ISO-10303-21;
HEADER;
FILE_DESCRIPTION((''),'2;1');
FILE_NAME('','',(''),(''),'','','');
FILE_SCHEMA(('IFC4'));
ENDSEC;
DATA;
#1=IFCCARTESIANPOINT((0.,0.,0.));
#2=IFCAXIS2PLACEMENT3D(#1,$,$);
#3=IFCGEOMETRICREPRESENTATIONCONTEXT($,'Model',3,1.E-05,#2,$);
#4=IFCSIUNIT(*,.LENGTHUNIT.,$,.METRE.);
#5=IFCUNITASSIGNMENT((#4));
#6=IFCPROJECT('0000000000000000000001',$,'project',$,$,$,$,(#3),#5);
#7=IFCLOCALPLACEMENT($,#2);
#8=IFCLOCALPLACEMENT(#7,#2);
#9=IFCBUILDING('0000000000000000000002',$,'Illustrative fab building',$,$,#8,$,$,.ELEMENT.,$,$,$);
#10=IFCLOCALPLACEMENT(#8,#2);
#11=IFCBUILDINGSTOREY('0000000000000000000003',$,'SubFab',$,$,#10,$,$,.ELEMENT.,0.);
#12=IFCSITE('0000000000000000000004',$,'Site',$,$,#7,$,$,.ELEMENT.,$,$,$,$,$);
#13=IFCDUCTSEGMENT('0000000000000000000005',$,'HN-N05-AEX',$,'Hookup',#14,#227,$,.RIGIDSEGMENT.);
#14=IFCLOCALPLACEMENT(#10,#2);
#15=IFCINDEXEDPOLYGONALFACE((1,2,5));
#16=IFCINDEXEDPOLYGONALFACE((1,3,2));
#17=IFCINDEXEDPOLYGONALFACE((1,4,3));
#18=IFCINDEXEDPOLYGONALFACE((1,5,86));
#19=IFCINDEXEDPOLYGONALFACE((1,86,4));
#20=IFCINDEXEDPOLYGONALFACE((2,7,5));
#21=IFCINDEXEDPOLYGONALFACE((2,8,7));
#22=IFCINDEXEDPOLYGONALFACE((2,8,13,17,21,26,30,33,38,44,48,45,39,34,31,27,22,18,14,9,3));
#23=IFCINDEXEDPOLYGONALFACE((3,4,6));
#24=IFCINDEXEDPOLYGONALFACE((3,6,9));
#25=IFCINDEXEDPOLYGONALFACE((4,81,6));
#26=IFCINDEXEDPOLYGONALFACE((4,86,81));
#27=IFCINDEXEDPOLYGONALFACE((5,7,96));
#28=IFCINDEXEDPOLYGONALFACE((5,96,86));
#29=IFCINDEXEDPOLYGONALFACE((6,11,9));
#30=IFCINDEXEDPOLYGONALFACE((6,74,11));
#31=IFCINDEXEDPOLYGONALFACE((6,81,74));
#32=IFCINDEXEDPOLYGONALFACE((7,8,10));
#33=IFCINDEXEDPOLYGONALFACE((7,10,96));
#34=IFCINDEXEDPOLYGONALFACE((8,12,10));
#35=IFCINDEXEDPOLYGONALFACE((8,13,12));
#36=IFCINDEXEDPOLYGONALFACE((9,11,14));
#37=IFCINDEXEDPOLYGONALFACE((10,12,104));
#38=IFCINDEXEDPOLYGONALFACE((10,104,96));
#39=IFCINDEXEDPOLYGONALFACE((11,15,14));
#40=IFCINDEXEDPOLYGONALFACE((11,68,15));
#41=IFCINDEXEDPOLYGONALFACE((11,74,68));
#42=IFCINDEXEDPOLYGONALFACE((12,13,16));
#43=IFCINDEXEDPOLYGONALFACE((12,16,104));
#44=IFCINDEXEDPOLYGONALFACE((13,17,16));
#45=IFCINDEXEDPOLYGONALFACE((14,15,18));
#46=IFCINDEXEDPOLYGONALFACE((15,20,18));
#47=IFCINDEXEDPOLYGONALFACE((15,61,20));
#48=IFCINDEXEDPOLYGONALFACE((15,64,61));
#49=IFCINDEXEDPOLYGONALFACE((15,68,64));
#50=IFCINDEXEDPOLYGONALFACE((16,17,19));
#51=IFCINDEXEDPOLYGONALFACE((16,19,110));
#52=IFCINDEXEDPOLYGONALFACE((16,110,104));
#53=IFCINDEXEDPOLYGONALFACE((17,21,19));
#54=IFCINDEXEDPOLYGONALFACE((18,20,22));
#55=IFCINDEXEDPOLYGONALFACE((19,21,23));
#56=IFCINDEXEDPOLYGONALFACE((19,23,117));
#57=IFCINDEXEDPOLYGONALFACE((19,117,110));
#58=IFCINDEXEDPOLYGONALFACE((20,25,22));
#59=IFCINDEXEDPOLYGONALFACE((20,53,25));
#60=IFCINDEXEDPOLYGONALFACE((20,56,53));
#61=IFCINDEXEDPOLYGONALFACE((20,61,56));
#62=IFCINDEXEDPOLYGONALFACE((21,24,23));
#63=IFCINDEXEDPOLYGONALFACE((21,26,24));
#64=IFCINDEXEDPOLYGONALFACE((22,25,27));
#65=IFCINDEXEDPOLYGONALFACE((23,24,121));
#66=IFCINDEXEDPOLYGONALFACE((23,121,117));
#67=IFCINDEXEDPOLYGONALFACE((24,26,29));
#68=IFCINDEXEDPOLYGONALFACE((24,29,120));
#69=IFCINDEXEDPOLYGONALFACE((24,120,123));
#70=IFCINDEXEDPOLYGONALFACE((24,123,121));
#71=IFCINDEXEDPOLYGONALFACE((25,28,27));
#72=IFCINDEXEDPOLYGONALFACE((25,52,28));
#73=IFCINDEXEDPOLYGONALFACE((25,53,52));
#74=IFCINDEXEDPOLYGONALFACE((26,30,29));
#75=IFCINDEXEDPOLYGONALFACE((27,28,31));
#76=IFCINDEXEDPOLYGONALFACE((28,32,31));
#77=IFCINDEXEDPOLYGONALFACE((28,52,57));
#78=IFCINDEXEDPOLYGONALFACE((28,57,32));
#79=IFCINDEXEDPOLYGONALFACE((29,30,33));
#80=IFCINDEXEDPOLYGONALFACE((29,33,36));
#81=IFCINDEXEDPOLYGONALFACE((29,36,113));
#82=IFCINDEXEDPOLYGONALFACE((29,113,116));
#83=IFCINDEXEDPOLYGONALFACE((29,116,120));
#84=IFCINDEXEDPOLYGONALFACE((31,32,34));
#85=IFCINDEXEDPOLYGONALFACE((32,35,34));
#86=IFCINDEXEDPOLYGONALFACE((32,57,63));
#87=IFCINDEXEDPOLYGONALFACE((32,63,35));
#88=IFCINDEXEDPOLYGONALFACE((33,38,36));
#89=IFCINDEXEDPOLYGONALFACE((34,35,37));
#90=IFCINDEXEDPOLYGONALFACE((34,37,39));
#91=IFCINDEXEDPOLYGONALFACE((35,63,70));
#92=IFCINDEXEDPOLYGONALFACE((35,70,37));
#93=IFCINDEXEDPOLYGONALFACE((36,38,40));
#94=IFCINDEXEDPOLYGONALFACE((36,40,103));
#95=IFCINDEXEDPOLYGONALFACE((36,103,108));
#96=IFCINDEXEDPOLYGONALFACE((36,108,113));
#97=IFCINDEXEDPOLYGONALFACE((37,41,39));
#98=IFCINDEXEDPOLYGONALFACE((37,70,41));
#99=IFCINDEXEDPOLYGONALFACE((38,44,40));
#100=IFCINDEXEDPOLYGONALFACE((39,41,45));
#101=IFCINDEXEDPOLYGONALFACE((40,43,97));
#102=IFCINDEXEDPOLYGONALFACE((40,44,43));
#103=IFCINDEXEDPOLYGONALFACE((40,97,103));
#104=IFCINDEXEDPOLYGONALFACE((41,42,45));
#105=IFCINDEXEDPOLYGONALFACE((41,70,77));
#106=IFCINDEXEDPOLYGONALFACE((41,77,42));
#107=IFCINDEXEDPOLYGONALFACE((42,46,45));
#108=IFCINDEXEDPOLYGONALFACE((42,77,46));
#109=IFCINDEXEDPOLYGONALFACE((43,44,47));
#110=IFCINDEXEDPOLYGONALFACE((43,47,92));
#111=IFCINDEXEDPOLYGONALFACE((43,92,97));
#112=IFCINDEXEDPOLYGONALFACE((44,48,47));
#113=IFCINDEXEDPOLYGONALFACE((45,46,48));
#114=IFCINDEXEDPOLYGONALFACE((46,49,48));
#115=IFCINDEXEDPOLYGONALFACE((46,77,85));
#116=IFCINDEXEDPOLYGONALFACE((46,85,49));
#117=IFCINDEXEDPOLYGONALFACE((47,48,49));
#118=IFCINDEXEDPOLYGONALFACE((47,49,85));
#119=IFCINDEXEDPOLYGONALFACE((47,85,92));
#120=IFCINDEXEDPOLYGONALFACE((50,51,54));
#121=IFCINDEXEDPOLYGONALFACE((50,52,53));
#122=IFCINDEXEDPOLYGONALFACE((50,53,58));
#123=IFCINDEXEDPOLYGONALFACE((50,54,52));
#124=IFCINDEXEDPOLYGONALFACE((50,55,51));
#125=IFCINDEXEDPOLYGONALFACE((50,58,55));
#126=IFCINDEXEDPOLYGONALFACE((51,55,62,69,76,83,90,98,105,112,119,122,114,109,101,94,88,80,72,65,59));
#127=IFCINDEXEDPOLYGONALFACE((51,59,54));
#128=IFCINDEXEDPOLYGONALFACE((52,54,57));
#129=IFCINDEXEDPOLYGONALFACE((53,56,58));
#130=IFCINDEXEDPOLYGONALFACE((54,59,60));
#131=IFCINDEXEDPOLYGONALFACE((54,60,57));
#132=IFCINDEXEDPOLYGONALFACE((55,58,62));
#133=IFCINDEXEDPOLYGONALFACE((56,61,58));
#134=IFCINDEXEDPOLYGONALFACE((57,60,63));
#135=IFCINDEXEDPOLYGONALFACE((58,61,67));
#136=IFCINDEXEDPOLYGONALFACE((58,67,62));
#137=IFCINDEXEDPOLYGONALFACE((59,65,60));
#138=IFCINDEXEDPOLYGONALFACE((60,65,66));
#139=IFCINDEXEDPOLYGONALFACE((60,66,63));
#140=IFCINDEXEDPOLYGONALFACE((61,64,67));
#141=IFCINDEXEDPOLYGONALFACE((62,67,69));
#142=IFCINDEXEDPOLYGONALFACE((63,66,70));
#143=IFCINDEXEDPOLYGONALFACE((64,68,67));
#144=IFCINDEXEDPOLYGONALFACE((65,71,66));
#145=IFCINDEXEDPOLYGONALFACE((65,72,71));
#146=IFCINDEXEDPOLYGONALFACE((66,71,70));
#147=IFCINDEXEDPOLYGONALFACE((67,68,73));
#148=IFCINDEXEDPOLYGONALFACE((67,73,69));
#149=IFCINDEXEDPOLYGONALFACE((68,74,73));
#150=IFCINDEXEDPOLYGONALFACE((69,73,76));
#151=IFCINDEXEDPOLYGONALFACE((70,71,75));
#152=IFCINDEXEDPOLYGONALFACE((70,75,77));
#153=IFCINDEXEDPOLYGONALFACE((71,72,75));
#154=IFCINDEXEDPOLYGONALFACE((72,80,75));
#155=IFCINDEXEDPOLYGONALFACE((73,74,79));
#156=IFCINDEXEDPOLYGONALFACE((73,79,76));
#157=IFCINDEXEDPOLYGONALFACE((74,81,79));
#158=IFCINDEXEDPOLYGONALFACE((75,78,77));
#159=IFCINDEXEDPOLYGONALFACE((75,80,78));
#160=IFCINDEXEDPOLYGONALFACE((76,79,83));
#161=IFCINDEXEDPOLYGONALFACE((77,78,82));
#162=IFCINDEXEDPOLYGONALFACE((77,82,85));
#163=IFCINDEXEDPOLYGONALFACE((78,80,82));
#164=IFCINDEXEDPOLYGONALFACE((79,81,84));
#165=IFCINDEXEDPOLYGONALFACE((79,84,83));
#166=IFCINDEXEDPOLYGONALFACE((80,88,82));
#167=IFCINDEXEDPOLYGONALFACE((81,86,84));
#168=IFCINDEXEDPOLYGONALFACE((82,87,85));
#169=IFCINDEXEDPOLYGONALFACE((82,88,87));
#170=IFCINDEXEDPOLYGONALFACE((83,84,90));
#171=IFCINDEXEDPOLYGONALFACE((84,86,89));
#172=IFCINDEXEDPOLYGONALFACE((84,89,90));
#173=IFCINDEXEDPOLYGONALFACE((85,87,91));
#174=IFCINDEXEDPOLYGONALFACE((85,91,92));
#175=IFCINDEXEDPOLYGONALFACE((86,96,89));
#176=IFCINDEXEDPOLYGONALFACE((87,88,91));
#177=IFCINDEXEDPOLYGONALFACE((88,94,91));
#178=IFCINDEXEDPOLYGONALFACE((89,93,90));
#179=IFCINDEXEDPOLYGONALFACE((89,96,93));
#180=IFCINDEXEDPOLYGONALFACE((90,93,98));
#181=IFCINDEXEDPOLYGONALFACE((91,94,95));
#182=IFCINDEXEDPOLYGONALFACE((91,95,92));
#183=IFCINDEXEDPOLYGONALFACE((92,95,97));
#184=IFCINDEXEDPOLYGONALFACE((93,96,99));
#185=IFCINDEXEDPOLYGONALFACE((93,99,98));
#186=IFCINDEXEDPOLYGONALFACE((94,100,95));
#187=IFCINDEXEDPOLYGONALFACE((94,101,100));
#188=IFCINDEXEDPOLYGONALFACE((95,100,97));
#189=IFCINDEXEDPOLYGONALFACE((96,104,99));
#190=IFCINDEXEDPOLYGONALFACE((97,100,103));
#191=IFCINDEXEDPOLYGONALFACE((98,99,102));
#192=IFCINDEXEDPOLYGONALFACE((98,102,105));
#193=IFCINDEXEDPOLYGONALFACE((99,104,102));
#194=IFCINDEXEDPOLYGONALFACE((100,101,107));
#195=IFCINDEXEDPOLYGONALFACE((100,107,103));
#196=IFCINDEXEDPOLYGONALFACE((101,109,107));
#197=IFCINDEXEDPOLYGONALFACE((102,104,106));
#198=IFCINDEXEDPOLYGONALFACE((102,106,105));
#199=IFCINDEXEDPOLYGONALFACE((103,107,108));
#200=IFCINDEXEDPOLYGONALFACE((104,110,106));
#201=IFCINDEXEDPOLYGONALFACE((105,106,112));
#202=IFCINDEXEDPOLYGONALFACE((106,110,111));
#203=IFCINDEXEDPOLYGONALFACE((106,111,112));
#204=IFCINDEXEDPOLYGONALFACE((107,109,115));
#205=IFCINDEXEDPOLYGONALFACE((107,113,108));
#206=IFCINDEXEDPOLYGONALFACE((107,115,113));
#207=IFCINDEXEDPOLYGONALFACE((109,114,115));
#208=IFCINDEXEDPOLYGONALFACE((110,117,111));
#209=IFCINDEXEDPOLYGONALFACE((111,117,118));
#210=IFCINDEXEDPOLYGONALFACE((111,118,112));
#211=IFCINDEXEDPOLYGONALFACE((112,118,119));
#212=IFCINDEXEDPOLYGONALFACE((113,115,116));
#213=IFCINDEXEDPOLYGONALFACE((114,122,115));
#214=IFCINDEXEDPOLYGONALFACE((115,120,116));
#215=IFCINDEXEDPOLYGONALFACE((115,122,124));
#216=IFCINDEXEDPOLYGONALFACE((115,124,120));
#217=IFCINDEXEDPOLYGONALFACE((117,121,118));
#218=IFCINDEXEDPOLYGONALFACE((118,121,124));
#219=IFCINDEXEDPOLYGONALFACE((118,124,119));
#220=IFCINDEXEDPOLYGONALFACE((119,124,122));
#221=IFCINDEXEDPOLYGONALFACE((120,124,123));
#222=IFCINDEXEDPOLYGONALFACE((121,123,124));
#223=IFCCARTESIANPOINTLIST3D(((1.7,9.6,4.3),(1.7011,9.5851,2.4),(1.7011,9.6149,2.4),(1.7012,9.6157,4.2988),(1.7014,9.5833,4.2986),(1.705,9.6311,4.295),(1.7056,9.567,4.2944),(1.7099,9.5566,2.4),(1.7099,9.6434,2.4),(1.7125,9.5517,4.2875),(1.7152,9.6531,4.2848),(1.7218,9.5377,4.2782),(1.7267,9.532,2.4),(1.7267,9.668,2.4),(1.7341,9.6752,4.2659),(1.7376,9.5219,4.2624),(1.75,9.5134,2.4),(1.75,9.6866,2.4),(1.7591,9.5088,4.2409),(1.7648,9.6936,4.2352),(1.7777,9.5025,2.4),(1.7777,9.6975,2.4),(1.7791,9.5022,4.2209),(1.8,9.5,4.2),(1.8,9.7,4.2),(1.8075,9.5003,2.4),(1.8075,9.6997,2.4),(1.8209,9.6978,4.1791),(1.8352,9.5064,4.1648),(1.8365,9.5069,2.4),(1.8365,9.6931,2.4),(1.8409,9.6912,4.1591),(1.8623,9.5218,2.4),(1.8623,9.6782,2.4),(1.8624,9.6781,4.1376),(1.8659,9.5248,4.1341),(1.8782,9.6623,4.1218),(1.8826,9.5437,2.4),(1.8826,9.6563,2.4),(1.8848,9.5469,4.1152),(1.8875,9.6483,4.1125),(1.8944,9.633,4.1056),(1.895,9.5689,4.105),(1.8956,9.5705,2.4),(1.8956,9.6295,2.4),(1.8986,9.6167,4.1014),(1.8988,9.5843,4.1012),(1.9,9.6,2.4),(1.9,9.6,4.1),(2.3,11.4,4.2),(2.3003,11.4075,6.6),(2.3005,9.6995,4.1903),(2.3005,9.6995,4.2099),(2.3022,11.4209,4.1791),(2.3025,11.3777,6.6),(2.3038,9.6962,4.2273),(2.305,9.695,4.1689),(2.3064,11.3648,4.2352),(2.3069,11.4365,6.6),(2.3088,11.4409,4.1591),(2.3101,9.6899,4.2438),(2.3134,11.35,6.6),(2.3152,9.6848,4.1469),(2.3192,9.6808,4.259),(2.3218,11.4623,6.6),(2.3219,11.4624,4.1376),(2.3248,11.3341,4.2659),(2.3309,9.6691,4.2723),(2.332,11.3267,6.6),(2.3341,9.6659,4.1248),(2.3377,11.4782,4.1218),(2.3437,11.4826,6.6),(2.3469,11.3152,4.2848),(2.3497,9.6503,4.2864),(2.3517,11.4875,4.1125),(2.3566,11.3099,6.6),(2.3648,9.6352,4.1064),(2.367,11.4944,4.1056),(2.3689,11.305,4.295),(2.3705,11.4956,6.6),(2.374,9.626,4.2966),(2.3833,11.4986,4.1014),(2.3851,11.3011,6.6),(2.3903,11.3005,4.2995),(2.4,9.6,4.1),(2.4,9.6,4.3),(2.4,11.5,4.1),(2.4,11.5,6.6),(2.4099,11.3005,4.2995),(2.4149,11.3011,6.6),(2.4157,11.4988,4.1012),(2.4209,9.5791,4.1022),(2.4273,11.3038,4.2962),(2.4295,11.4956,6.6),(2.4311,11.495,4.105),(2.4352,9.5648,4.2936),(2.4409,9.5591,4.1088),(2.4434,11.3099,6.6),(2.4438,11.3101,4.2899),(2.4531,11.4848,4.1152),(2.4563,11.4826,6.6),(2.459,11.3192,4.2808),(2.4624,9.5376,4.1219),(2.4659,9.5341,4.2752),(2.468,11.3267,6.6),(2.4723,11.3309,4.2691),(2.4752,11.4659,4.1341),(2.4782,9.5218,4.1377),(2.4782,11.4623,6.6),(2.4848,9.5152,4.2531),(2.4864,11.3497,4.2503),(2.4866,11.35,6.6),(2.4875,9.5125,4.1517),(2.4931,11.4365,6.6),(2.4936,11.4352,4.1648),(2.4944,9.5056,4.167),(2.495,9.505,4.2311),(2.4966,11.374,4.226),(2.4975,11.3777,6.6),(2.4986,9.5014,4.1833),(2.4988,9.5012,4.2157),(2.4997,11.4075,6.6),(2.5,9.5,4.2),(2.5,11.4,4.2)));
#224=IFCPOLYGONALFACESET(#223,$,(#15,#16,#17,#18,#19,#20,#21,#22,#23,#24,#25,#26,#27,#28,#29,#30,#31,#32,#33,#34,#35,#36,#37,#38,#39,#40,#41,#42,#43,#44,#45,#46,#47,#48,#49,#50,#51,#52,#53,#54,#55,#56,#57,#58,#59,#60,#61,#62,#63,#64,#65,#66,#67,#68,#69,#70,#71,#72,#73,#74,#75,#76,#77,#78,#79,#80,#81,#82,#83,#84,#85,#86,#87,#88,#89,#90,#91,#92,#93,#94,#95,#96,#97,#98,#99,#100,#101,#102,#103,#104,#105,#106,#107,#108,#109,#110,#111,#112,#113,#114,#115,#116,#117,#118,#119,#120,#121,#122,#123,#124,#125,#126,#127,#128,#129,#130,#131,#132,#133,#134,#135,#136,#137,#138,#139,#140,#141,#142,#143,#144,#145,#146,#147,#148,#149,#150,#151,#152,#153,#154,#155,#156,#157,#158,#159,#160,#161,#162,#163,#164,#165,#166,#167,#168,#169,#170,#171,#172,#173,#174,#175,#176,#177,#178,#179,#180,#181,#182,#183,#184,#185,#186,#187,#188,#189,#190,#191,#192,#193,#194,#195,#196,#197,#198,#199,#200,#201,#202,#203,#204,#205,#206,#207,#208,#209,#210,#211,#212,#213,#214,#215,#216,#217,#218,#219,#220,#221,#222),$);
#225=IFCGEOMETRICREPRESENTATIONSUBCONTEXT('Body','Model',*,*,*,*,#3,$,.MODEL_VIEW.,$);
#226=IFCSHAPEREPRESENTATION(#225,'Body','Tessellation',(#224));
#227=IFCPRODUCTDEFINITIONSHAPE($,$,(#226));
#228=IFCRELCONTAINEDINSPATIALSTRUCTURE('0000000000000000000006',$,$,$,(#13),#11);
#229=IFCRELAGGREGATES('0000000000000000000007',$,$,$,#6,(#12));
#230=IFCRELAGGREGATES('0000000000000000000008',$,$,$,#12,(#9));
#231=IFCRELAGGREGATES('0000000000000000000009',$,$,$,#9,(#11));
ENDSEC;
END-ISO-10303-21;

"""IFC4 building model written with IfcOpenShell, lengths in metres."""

from ifc_helpers import new_model, entity, si_unit, origin, place, context, subcontext, project, spatial, element, save


model = new_model("IFC4")

# Units and contexts
model_context = context("Model", 3, precision=1e-05, world=origin())
body_context = subcontext(model_context, "Body", "Model", "MODEL_VIEW")
ifc_project = project(units=[si_unit("LENGTHUNIT", "METRE")], contexts=[model_context])

# Site, building, storey
site_placement = place(None, origin())
site = spatial("IfcSite", under=ifc_project, at=site_placement, Name="Site", CompositionType="ELEMENT")
building_placement = place(site_placement, origin())
building = spatial("IfcBuilding", under=site, at=building_placement, Name="Illustrative fab building", CompositionType="ELEMENT")
storey_placement = place(building_placement, origin())
storey = spatial("IfcBuildingStorey", under=building, at=storey_placement, Name="SubFab", CompositionType="ELEMENT", Elevation=0.0)

# Duct segment
duct_segment_1_placement = place(storey_placement, origin())
element("IfcDuctSegment", 1, at=duct_segment_1_placement, inside=storey, Name="HN-N05-AEX", ObjectType="Hookup", PredefinedType="RIGIDSEGMENT", context=body_context, shape_type="AdvancedSweptSolid", body=[
    entity("IfcSweptDiskSolid", entity("IfcPolyline", [entity("IfcCartesianPoint", [1.8, 9.6, 2.4]), entity("IfcCartesianPoint", [1.8, 9.6, 4.2]), entity("IfcCartesianPoint", [2.4, 9.6, 4.2]), entity("IfcCartesianPoint", [2.4, 11.4, 4.2]), entity("IfcCartesianPoint", [2.4, 11.4, 6.6])]), 0.1),
])

save(model, "model.ifc")
